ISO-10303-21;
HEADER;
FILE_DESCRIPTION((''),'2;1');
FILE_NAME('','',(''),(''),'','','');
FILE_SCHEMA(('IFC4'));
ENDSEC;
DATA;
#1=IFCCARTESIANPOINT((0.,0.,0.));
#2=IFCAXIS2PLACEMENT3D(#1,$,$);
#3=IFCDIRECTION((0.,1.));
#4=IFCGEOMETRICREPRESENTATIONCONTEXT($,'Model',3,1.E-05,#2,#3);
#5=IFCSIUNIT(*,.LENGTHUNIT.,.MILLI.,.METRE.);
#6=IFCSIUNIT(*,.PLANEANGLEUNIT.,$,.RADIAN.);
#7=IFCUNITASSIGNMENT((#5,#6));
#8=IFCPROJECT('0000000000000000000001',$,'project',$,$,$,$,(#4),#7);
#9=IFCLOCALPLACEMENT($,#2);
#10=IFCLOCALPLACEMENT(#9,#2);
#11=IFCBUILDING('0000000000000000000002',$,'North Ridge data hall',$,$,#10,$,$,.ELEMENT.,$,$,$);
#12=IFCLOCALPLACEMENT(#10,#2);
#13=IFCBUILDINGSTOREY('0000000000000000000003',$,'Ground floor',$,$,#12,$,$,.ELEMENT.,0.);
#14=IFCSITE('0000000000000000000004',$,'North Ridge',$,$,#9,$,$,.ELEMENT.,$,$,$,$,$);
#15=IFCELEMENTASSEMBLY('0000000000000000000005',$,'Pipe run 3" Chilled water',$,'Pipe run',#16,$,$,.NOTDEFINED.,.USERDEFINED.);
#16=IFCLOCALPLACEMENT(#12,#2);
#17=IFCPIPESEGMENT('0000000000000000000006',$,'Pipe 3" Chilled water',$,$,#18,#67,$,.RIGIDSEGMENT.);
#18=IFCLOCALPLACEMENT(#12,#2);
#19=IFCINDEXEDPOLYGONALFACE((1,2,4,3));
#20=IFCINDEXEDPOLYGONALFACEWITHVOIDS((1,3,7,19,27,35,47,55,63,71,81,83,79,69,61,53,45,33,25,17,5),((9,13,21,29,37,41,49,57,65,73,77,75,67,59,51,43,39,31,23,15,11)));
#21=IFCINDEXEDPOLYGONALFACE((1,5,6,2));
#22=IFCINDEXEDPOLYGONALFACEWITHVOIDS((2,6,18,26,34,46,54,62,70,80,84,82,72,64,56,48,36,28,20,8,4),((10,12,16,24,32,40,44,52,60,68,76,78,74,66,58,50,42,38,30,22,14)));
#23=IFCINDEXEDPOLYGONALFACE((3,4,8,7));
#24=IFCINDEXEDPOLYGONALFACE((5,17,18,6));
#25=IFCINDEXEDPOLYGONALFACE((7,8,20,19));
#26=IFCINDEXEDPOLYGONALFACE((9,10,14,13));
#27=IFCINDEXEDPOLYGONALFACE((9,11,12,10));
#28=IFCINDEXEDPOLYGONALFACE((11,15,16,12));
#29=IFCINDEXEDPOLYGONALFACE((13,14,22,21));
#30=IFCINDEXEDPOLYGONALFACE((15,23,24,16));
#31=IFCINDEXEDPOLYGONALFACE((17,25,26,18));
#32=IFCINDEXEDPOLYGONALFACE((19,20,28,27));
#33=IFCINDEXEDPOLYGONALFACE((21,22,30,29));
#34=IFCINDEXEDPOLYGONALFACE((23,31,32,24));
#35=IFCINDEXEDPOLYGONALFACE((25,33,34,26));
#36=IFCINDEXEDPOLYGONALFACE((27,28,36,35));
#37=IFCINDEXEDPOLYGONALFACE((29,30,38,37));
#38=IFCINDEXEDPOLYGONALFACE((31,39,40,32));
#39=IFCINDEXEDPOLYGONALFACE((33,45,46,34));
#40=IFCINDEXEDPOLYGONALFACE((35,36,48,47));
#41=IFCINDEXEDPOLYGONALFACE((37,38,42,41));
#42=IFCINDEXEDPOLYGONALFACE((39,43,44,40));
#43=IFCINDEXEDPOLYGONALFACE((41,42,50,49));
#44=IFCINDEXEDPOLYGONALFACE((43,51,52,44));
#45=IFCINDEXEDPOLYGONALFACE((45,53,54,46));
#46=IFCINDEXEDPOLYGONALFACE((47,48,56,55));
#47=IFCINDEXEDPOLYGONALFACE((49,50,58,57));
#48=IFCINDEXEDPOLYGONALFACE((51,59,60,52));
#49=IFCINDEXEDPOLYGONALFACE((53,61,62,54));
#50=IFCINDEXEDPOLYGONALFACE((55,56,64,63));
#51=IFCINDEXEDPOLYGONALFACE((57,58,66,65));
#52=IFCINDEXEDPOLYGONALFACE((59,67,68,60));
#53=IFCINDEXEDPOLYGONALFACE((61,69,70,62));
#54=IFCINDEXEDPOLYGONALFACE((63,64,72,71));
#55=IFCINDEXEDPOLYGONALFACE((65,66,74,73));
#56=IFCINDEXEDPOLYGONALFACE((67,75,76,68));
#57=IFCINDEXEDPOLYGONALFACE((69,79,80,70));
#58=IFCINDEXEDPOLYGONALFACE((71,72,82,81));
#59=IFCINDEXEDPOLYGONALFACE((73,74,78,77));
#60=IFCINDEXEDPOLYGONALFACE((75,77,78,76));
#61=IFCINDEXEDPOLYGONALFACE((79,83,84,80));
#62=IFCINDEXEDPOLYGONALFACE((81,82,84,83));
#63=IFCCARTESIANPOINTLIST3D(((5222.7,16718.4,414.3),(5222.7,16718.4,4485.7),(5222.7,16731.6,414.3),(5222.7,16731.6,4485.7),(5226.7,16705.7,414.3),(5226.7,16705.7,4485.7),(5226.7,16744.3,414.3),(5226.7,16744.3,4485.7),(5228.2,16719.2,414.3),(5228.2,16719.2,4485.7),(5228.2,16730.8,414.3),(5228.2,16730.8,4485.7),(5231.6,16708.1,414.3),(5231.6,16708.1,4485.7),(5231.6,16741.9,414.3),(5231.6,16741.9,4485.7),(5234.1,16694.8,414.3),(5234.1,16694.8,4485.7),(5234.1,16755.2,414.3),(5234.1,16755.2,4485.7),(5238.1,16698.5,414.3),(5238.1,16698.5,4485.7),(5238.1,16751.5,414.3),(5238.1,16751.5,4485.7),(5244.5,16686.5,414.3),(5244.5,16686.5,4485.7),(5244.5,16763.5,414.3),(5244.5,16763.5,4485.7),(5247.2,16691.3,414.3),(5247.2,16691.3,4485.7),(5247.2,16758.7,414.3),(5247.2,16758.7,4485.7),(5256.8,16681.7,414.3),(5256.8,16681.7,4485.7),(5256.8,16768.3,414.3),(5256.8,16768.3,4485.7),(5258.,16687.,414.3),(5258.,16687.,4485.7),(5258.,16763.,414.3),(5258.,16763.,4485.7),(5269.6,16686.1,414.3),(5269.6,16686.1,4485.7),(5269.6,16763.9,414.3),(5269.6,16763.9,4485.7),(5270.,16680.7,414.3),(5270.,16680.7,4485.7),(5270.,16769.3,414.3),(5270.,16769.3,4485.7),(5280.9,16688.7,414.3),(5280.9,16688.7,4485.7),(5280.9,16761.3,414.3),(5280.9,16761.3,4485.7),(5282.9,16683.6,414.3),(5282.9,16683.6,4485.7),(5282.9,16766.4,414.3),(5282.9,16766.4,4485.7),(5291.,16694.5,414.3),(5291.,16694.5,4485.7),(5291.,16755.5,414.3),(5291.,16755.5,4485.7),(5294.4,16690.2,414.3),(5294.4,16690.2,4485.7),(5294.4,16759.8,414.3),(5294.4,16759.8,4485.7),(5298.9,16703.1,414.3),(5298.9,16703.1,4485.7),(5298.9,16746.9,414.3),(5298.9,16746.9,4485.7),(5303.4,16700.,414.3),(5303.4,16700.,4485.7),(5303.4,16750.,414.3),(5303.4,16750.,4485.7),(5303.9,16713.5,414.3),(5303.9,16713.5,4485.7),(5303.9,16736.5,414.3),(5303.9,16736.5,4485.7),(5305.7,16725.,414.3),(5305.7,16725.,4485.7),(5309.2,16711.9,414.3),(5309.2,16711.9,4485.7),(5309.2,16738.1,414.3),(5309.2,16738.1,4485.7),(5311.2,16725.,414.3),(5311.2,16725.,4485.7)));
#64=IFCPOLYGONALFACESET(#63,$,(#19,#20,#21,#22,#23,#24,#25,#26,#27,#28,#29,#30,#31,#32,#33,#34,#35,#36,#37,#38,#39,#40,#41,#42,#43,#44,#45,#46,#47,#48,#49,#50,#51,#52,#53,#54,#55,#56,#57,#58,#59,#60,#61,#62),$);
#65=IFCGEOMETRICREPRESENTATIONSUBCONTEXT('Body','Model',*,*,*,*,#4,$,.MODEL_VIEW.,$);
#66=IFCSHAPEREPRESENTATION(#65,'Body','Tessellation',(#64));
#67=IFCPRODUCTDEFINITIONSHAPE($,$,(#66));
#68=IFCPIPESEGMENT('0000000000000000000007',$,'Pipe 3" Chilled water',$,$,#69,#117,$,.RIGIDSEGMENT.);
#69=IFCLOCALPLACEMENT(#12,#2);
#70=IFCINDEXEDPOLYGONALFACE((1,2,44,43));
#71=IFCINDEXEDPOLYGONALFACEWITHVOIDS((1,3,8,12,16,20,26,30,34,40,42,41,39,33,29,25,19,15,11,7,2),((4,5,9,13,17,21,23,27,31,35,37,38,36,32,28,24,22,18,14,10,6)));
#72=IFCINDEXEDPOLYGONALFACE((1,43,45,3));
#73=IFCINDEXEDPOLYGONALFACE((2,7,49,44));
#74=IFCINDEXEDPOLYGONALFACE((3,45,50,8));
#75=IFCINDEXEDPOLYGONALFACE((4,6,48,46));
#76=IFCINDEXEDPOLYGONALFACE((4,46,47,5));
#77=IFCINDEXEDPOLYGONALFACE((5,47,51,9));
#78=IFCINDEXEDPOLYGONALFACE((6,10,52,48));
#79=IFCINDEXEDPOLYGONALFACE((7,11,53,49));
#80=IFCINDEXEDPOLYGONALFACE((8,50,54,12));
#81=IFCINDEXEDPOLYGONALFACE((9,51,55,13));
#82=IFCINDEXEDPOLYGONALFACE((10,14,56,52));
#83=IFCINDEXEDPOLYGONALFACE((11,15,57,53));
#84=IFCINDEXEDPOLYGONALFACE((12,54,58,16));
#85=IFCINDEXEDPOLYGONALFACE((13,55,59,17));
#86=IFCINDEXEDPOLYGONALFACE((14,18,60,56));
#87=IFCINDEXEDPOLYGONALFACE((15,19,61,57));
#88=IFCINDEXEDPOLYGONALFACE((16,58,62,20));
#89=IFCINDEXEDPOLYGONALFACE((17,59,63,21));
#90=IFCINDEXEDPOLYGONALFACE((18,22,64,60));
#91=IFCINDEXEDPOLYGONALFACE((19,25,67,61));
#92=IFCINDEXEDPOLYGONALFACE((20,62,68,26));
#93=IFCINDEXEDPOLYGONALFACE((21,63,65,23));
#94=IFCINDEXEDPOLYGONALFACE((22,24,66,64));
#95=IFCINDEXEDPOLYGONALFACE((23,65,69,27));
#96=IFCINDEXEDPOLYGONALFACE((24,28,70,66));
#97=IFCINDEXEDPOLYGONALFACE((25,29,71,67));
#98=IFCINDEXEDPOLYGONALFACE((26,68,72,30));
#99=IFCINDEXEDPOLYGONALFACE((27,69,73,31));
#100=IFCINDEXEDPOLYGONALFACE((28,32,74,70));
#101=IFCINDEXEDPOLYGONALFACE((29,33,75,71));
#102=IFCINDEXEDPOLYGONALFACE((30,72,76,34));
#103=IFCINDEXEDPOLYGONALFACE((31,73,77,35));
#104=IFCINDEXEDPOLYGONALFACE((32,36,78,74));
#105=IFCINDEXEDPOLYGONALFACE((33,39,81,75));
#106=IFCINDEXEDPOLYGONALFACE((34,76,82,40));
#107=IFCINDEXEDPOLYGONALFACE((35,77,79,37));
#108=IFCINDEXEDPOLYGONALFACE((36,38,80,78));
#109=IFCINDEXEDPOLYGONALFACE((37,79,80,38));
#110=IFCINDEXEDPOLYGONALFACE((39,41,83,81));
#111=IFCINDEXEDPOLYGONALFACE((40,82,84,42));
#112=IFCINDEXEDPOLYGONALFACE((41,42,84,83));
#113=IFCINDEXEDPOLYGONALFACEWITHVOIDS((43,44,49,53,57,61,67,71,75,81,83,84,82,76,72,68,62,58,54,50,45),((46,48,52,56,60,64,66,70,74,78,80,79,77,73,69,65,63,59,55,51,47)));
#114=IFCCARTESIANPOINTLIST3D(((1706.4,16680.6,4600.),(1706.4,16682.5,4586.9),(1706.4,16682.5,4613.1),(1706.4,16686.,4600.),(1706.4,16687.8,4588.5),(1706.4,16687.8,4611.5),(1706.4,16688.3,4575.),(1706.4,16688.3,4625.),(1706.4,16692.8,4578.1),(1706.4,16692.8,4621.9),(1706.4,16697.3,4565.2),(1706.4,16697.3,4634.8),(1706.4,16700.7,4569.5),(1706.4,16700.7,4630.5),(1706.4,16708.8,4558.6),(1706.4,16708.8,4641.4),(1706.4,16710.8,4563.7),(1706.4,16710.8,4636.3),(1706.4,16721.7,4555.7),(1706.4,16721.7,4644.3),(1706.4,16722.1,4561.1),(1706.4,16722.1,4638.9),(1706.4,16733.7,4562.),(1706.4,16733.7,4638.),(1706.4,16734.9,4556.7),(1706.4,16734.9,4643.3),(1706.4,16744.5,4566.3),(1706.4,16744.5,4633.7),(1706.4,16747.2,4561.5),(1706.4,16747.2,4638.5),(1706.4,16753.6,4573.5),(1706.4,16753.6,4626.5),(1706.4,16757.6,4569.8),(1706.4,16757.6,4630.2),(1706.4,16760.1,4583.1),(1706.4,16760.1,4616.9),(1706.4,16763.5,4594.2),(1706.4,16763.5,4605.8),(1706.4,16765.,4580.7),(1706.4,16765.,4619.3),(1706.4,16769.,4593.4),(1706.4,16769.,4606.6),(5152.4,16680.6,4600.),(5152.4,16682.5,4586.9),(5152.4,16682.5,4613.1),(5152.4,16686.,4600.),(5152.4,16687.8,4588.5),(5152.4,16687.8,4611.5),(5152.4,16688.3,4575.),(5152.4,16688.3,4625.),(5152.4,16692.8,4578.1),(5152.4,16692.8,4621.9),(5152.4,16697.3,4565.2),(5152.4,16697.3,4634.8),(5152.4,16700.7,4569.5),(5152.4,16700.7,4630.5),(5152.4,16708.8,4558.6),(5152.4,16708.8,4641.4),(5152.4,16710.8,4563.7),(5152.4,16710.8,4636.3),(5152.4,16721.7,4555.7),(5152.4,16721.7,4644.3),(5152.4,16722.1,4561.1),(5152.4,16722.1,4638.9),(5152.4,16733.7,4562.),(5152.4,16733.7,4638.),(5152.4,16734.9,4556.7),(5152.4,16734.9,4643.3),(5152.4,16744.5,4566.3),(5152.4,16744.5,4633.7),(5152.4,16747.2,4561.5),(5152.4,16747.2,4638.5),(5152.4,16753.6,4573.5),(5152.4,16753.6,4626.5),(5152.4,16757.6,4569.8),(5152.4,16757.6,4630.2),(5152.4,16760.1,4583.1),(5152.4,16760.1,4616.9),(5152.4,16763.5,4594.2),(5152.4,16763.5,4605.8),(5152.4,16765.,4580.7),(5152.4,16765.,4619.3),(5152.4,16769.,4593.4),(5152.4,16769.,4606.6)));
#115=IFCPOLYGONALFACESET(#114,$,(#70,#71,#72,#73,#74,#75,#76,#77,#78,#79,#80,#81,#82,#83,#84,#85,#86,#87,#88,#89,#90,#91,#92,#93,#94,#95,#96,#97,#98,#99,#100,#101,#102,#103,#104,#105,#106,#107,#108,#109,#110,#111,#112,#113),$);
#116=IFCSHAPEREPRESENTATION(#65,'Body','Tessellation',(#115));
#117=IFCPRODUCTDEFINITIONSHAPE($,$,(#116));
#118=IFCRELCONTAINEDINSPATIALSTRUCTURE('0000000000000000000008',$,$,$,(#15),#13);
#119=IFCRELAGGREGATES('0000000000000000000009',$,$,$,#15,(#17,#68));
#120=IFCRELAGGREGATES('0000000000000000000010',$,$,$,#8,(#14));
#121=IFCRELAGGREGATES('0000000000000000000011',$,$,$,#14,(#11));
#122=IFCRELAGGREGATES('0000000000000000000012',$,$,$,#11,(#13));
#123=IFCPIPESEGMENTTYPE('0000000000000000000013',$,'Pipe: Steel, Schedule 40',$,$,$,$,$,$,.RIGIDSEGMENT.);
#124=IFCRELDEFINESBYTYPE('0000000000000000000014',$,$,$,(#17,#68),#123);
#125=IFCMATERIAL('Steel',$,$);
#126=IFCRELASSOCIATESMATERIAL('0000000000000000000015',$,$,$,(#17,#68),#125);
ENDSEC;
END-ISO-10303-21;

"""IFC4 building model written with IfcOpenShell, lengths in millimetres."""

from ifc_helpers import new_model, si_unit, direction, frame, origin, origin_with_axes, origin_2d, place, context, subcontext, project, spatial, hollow_circle, extrude, material, type_object, element, aggregate, save


model = new_model("IFC4")

# Units and contexts
model_context = context("Model", 3, precision=1e-05, world=origin(), true_north=direction((0.0, 1.0)))
body_context = subcontext(model_context, "Body", "Model", "MODEL_VIEW")
ifc_project = project(units=[si_unit("LENGTHUNIT", "METRE", prefix="MILLI"), si_unit("PLANEANGLEUNIT", "RADIAN")], contexts=[model_context])

# Site, building, storey
site_placement = place(None, origin())
site = spatial("IfcSite", under=ifc_project, at=site_placement, Name="North Ridge", CompositionType="ELEMENT")
building_placement = place(site_placement, origin())
building = spatial("IfcBuilding", under=site, at=building_placement, Name="North Ridge data hall", CompositionType="ELEMENT")
storey_placement = place(building_placement, origin())
storey = spatial("IfcBuildingStorey", under=building, at=storey_placement, Name="Ground floor", CompositionType="ELEMENT", Elevation=0.0)

# Shared definitions
ifc_material_1 = material(Name="Steel")
pipe_segment_type = type_object("IfcPipeSegmentType", Name="Pipe: Steel, Schedule 40", PredefinedType="RIGIDSEGMENT")

# Element assembly, pipe segments
assembly_1_placement = place(storey_placement, origin_with_axes())
assembly_1 = element("IfcElementAssembly", 1, at=assembly_1_placement, inside=storey, Name="Pipe run 3\" Chilled water", ObjectType="Pipe run", AssemblyPlace="NOTDEFINED", PredefinedType="USERDEFINED")
pipe_segment_1_placement = place(storey_placement, origin_with_axes())
pipe_segment_1 = element("IfcPipeSegment", 2, at=pipe_segment_1_placement, type_object=pipe_segment_type, material=ifc_material_1, Name="Pipe 3\" Chilled water", PredefinedType="RIGIDSEGMENT", context=body_context, shape_type="SweptSolid", body=[
    extrude(hollow_circle(Radius=44.5, WallThickness=5.5, at=origin_2d()), frame((5266.7, 16725.0, 414.3), z_axis=(0.0, 0.0, 1.0), x_axis=(1.0, 0.0, 0.0)), (0.0, 0.0, 1.0), 4071.4),
])
pipe_segment_2_placement = place(storey_placement, origin_with_axes())
pipe_segment_2 = element("IfcPipeSegment", 3, at=pipe_segment_2_placement, type_object=pipe_segment_type, material=ifc_material_1, Name="Pipe 3\" Chilled water", PredefinedType="RIGIDSEGMENT", context=body_context, shape_type="SweptSolid", body=[
    extrude(hollow_circle(Radius=44.5, WallThickness=5.5, at=origin_2d()), frame((5152.4, 16725.0, 4600.0), z_axis=(-1.0, 0.0, 0.0), x_axis=(0.0, -1.0, 0.0)), (0.0, 0.0, 1.0), 3446.0),
])

aggregate(assembly_1, [pipe_segment_1, pipe_segment_2])

save(model, "model.ifc")
